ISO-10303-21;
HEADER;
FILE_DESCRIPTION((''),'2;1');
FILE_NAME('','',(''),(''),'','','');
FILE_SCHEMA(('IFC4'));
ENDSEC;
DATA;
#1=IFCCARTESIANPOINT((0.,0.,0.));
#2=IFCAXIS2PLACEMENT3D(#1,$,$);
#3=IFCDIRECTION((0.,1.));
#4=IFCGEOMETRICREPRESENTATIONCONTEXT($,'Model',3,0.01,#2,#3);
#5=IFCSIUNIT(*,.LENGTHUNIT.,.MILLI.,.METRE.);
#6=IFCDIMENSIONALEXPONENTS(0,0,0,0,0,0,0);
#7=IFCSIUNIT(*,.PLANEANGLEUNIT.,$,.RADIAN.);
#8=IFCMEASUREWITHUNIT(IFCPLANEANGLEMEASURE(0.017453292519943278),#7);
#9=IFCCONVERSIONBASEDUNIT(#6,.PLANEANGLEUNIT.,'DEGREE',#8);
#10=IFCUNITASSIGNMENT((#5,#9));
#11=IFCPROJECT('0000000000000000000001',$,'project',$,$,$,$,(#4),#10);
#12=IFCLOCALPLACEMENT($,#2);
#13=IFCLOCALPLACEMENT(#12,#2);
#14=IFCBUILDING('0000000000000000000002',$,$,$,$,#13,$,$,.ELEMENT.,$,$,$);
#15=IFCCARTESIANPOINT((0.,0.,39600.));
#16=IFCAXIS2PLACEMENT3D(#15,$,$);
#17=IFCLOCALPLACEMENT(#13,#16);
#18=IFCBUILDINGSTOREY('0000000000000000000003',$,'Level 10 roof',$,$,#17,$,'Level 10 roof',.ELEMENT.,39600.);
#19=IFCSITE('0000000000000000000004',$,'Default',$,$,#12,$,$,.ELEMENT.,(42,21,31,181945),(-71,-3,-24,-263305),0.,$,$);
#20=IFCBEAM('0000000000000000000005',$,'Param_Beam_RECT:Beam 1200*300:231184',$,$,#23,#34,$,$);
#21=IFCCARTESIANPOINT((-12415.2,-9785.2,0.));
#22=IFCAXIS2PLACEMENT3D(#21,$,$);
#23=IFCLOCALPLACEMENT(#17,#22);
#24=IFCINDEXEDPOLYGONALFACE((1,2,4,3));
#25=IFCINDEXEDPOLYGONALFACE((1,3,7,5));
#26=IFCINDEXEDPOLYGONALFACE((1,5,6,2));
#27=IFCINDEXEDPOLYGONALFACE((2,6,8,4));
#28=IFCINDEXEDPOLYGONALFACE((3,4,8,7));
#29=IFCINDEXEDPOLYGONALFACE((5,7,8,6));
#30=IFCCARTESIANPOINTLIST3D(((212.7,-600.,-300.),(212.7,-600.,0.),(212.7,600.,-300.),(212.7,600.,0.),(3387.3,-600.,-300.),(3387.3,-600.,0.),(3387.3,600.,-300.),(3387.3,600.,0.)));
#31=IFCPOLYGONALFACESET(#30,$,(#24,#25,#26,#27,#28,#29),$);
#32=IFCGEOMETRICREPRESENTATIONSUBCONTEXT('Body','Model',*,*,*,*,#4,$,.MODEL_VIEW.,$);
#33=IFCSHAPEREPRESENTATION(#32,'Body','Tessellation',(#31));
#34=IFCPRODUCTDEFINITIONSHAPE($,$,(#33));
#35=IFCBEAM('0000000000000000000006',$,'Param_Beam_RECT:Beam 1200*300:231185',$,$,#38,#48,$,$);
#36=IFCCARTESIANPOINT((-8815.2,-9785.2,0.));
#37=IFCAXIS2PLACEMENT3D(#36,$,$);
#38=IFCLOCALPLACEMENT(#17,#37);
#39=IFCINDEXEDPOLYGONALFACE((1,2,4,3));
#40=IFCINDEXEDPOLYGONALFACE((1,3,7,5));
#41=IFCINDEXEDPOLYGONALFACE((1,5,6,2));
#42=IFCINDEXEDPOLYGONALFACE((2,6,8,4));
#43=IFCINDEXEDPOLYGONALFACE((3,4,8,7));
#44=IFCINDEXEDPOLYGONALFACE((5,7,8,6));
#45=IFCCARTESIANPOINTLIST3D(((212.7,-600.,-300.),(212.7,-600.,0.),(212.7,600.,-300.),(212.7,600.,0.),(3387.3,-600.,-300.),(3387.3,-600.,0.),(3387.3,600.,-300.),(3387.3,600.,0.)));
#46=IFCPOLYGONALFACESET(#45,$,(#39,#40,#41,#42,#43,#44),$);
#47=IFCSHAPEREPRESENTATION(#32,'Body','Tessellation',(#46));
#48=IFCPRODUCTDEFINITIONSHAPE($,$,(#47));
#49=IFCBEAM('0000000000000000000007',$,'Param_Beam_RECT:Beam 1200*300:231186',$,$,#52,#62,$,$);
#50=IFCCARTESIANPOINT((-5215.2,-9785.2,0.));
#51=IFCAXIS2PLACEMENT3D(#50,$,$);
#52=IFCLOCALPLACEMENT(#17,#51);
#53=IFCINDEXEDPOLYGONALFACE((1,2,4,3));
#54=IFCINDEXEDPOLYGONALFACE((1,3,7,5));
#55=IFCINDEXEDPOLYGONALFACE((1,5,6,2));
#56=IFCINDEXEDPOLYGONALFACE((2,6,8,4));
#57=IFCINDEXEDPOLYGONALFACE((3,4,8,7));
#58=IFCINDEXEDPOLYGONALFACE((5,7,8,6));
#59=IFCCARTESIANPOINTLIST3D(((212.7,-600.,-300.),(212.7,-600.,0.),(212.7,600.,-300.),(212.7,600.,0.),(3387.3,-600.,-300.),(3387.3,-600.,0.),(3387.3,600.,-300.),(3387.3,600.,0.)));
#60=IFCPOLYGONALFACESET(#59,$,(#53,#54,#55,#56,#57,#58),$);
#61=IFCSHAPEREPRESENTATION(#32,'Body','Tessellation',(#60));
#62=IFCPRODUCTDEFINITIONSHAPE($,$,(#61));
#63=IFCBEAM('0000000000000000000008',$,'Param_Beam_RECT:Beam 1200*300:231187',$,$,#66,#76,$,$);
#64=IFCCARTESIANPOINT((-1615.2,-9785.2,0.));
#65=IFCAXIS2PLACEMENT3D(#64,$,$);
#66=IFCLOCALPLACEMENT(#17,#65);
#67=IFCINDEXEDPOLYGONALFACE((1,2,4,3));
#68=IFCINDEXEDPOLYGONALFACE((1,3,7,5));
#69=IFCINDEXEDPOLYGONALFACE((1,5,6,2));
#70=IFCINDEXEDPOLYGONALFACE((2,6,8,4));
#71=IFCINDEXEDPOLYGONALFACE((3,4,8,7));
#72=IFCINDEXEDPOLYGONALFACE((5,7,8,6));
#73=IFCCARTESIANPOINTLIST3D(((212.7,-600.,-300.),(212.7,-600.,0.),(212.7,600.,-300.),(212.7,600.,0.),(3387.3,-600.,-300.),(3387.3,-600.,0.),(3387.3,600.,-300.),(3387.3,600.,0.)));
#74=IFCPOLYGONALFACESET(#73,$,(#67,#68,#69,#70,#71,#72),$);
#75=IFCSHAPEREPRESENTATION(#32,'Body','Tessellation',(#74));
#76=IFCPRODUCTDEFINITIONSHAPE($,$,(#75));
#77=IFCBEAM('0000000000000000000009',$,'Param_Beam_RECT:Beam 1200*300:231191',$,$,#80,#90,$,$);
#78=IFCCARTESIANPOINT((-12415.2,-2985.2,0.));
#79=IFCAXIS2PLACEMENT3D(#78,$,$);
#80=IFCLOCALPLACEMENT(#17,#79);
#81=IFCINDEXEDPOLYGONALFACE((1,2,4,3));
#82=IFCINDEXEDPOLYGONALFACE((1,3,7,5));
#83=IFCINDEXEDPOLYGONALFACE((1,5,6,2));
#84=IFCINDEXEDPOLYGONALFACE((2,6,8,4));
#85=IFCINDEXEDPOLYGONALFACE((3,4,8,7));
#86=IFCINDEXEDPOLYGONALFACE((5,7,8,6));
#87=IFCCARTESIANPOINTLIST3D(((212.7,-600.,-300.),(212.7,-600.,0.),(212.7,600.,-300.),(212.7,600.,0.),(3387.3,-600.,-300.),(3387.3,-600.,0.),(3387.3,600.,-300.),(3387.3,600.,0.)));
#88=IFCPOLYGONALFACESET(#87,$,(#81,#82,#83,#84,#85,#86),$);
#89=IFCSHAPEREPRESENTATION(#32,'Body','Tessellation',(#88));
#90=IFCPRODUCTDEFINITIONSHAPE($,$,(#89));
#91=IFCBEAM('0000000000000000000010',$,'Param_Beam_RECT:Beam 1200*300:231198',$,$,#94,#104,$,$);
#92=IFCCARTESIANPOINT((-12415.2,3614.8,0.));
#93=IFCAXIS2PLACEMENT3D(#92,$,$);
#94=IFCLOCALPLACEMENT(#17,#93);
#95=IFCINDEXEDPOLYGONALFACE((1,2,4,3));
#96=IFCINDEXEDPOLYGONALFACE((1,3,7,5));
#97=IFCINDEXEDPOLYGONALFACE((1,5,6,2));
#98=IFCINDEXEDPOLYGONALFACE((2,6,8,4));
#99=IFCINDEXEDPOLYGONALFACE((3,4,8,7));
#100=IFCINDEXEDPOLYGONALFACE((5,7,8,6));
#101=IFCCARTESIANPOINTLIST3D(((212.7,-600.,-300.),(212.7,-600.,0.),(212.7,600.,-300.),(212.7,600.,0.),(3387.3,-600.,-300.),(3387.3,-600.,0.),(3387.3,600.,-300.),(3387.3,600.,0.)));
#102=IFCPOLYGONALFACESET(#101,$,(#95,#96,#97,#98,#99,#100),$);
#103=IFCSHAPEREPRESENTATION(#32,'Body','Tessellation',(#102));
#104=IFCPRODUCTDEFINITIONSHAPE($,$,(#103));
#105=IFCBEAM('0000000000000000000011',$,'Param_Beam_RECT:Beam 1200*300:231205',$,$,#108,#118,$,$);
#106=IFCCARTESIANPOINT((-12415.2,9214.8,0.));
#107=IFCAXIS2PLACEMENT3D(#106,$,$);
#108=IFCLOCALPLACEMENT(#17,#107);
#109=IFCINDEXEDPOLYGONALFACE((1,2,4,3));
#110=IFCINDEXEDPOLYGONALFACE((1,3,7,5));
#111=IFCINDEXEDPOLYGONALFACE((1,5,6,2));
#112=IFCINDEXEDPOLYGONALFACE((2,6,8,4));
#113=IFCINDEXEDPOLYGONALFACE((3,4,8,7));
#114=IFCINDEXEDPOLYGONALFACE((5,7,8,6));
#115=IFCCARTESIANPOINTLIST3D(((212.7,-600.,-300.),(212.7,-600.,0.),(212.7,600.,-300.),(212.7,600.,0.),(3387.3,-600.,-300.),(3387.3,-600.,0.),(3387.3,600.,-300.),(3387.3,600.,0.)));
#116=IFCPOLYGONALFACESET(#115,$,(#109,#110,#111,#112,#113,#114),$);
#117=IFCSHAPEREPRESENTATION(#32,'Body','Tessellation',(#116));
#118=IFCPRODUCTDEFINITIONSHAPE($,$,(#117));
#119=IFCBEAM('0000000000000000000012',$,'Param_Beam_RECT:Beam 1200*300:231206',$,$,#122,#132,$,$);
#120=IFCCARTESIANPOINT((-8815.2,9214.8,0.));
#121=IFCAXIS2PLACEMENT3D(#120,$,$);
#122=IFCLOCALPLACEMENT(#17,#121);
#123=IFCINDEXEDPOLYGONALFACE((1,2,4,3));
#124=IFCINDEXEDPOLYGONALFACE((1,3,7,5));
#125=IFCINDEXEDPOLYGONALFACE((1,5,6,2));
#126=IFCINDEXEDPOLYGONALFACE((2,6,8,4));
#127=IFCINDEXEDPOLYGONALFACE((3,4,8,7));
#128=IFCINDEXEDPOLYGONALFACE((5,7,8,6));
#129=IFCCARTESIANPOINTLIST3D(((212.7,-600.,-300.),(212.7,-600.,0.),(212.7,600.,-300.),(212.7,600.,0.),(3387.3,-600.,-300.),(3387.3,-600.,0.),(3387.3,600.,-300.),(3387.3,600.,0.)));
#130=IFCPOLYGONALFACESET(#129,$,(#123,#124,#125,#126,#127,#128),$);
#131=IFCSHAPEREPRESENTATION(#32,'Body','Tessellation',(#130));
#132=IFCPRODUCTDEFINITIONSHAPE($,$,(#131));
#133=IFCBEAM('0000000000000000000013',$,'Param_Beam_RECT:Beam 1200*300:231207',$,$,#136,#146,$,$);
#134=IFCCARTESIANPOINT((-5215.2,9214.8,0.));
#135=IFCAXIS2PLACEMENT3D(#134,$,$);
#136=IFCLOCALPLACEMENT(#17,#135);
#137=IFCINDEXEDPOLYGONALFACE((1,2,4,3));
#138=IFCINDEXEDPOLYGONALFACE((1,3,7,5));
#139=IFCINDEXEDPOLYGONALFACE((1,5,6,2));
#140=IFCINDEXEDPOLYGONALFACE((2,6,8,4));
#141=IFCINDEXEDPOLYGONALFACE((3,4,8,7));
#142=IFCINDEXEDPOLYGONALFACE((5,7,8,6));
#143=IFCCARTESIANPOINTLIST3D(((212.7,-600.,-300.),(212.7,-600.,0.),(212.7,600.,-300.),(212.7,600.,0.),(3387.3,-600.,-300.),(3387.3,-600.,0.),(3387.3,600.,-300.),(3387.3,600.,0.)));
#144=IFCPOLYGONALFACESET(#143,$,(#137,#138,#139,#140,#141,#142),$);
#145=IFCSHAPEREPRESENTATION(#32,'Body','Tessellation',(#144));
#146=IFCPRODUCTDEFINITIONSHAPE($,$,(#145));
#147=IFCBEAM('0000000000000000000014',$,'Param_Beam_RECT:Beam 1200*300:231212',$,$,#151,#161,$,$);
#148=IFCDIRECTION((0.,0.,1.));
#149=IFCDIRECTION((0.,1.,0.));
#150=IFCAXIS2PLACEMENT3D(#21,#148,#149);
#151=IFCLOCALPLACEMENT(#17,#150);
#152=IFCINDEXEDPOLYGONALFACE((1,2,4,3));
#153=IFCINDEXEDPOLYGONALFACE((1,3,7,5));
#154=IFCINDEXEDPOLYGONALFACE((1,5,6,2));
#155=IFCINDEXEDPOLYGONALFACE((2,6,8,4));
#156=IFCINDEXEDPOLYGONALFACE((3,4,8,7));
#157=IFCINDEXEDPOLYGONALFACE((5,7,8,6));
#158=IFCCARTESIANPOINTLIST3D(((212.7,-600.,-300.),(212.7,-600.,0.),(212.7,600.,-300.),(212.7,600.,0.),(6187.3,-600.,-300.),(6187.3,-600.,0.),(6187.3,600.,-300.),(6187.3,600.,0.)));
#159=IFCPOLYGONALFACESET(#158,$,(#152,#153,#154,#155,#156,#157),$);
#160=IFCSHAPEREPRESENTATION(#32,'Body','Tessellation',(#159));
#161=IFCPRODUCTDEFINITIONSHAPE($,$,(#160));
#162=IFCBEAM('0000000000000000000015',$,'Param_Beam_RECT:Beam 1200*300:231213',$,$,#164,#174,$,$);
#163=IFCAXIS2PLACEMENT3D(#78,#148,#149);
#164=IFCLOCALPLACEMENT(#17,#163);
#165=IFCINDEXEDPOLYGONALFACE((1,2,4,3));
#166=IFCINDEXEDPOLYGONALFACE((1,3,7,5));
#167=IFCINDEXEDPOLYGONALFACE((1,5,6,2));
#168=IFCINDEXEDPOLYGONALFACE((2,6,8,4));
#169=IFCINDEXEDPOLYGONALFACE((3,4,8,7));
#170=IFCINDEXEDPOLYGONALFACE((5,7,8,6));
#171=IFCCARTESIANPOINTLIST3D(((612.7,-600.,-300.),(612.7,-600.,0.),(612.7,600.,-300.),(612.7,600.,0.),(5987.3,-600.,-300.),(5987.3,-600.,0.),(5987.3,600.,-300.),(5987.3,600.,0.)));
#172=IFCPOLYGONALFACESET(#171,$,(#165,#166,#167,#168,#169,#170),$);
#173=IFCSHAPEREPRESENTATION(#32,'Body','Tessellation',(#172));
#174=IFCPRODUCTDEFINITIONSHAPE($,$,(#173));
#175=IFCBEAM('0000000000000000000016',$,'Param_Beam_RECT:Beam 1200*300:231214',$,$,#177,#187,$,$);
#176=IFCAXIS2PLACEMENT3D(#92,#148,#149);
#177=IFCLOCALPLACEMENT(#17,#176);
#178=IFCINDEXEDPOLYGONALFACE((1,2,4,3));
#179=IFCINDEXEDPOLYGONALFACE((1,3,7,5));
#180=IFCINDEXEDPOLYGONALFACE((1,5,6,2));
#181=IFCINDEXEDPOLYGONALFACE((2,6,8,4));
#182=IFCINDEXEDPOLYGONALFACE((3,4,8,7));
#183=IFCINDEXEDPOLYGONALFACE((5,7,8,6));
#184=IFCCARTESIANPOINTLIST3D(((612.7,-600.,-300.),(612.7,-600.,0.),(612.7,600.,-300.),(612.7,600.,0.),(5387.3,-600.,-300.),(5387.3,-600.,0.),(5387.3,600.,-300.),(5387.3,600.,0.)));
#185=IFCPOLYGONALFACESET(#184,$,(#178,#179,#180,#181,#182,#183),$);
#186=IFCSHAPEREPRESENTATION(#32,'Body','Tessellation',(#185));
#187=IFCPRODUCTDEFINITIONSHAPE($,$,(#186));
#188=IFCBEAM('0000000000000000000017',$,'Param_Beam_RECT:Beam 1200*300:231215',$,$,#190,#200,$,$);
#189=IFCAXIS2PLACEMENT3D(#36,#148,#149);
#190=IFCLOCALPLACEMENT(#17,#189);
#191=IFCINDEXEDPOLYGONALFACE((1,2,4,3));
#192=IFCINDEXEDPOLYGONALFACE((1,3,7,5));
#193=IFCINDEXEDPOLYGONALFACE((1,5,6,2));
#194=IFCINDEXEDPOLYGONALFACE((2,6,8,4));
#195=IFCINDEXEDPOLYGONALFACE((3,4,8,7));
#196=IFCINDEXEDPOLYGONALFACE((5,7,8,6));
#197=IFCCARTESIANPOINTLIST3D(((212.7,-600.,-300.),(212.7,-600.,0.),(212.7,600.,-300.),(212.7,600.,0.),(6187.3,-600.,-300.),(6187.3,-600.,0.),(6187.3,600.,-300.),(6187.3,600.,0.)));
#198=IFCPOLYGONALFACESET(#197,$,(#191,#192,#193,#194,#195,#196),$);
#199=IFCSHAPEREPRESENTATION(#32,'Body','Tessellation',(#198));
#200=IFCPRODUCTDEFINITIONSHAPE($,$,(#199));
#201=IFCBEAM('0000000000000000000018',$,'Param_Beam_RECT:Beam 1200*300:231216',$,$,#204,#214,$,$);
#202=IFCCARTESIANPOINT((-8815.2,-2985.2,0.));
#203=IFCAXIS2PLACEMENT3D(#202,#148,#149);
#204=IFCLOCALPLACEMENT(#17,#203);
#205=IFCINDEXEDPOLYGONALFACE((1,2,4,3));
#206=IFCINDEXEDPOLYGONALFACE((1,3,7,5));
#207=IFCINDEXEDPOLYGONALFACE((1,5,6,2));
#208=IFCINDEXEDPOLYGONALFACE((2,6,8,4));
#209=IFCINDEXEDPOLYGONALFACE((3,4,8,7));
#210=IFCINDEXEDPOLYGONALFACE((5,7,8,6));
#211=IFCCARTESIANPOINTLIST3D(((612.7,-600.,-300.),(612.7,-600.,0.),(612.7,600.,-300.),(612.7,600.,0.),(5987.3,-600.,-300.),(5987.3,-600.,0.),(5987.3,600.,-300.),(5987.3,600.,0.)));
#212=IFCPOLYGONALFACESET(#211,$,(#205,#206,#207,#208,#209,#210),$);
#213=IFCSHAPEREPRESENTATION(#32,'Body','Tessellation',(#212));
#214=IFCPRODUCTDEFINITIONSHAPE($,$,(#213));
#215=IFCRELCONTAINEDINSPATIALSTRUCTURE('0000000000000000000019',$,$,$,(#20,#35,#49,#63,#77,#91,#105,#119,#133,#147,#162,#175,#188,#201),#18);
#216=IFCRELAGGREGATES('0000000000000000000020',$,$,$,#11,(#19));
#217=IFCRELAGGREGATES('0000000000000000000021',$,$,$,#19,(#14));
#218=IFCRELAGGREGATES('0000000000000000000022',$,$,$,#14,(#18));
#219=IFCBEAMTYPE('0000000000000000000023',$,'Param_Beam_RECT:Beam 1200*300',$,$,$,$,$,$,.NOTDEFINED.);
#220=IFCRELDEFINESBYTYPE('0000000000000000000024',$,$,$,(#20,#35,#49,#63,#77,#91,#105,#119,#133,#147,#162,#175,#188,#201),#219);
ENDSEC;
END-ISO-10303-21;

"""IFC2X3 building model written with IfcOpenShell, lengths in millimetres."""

from ifc_helpers import new_model, entity, si_unit, converted_unit, direction, frame, frame_2d, origin, origin_2d_with_axis, place, context, subcontext, project, spatial, rectangle, extrude, type_object, element, save


model = new_model("IFC2X3")

# Units and contexts
model_context = context("Model", 3, precision=0.01, world=origin(), true_north=direction((0.0, 1.0)))
body_context = subcontext(model_context, "Body", "Model", "MODEL_VIEW")
ifc_project = project(units=[si_unit("LENGTHUNIT", "METRE", prefix="MILLI"), converted_unit("PLANEANGLEUNIT", "DEGREE", entity("IfcPlaneAngleMeasure", 0.017453292519943278), si_unit("PLANEANGLEUNIT", "RADIAN"), dimensions=[0, 0, 0, 0, 0, 0, 0])], contexts=[model_context])

# Site, building, storey
site_placement = place(None, origin())
site = spatial("IfcSite", under=ifc_project, at=site_placement, Name="Default", CompositionType="ELEMENT", RefLatitude=(42, 21, 31, 181945), RefLongitude=(-71, -3, -24, -263305), RefElevation=0.0)
building_placement = place(site_placement, origin())
building = spatial("IfcBuilding", under=site, at=building_placement, CompositionType="ELEMENT")
storey_placement = place(building_placement, frame((0.0, 0.0, 39600.0)))
storey = spatial("IfcBuildingStorey", under=building, at=storey_placement, Name="Level 10 roof", LongName="Level 10 roof", CompositionType="ELEMENT", Elevation=39600.0)

# Beams
beam_type_1 = type_object("IfcBeamType", Name="Param_Beam_RECT:Beam 1200*300", PredefinedType="NOTDEFINED")
beam_1_placement = place(storey_placement, frame((-12415.2, -9785.2, 0.0)))
element("IfcBeam", 1, at=beam_1_placement, inside=storey, type_object=beam_type_1, Name="Param_Beam_RECT:Beam 1200*300:231184", context=body_context, shape_type="SweptSolid", body=[
    extrude(rectangle(XDim=300.0, YDim=1200.0, at=frame_2d((0.0, 0.0), x_axis=(1.0, 0.0))), frame((212.7, 0.0, -150.0), z_axis=(1.0, 0.0, 0.0), x_axis=(0.0, 0.0, -1.0)), (0.0, 0.0, 1.0), 3174.6),
])
beam_2_placement = place(storey_placement, frame((-8815.2, -9785.2, 0.0)))
element("IfcBeam", 2, at=beam_2_placement, inside=storey, type_object=beam_type_1, Name="Param_Beam_RECT:Beam 1200*300:231185", context=body_context, shape_type="SweptSolid", body=[
    extrude(rectangle(XDim=300.0, YDim=1200.0, at=frame_2d((0.0, 0.0), x_axis=(1.0, 0.0))), frame((212.7, 0.0, -150.0), z_axis=(1.0, 0.0, 0.0), x_axis=(0.0, 0.0, -1.0)), (0.0, 0.0, 1.0), 3174.6),
])
beam_3_placement = place(storey_placement, frame((-5215.2, -9785.2, 0.0)))
element("IfcBeam", 3, at=beam_3_placement, inside=storey, type_object=beam_type_1, Name="Param_Beam_RECT:Beam 1200*300:231186", context=body_context, shape_type="SweptSolid", body=[
    extrude(rectangle(XDim=300.0, YDim=1200.0, at=frame_2d((0.0, 0.0), x_axis=(1.0, 0.0))), frame((212.7, 0.0, -150.0), z_axis=(1.0, 0.0, 0.0), x_axis=(0.0, 0.0, -1.0)), (0.0, 0.0, 1.0), 3174.6),
])
beam_4_placement = place(storey_placement, frame((-1615.2, -9785.2, 0.0)))
element("IfcBeam", 4, at=beam_4_placement, inside=storey, type_object=beam_type_1, Name="Param_Beam_RECT:Beam 1200*300:231187", context=body_context, shape_type="SweptSolid", body=[
    extrude(rectangle(XDim=300.0, YDim=1200.0, at=origin_2d_with_axis()), frame((212.7, 0.0, -150.0), z_axis=(1.0, 0.0, 0.0), x_axis=(0.0, 0.0, -1.0)), (0.0, 0.0, 1.0), 3174.6),
])
beam_5_placement = place(storey_placement, frame((-12415.2, -2985.2, 0.0)))
element("IfcBeam", 5, at=beam_5_placement, inside=storey, type_object=beam_type_1, Name="Param_Beam_RECT:Beam 1200*300:231191", context=body_context, shape_type="SweptSolid", body=[
    extrude(rectangle(XDim=300.0, YDim=1200.0, at=frame_2d((0.0, 0.0), x_axis=(1.0, 0.0))), frame((212.7, 0.0, -150.0), z_axis=(1.0, 0.0, 0.0), x_axis=(0.0, 0.0, -1.0)), (0.0, 0.0, 1.0), 3174.6),
])
beam_6_placement = place(storey_placement, frame((-12415.2, 3614.8, 0.0)))
element("IfcBeam", 6, at=beam_6_placement, inside=storey, type_object=beam_type_1, Name="Param_Beam_RECT:Beam 1200*300:231198", context=body_context, shape_type="SweptSolid", body=[
    extrude(rectangle(XDim=300.0, YDim=1200.0, at=origin_2d_with_axis()), frame((212.7, 0.0, -150.0), z_axis=(1.0, 0.0, 0.0), x_axis=(0.0, 0.0, -1.0)), (0.0, 0.0, 1.0), 3174.6),
])
beam_7_placement = place(storey_placement, frame((-12415.2, 9214.8, 0.0)))
element("IfcBeam", 7, at=beam_7_placement, inside=storey, type_object=beam_type_1, Name="Param_Beam_RECT:Beam 1200*300:231205", context=body_context, shape_type="SweptSolid", body=[
    extrude(rectangle(XDim=300.0, YDim=1200.0, at=frame_2d((0.0, 0.0), x_axis=(1.0, 0.0))), frame((212.7, 0.0, -150.0), z_axis=(1.0, 0.0, 0.0), x_axis=(0.0, 0.0, -1.0)), (0.0, 0.0, 1.0), 3174.6),
])
for number, where, name in (
    (8, (-8815.2, 9214.8, 0.0), "Param_Beam_RECT:Beam 1200*300:231206"),
    (9, (-5215.2, 9214.8, 0.0), "Param_Beam_RECT:Beam 1200*300:231207"),
):
    element("IfcBeam", number, at=place(storey_placement, frame(where)), inside=storey, type_object=beam_type_1, Name=name, context=body_context, shape_type="SweptSolid", body=[
        extrude(rectangle(XDim=300.0, YDim=1200.0, at=frame_2d((0.0, 0.0), x_axis=(1.0, 0.0))), frame((212.7, 0.0, -150.0), z_axis=(1.0, 0.0, 0.0), x_axis=(0.0, 0.0, -1.0)), (0.0, 0.0, 1.0), 3174.6),
    ])
beam_8_placement = place(storey_placement, frame((-12415.2, -9785.2, 0.0), z_axis=(0.0, 0.0, 1.0), x_axis=(0.0, 1.0, 0.0)))
element("IfcBeam", 10, at=beam_8_placement, inside=storey, type_object=beam_type_1, Name="Param_Beam_RECT:Beam 1200*300:231212", context=body_context, shape_type="SweptSolid", body=[
    extrude(rectangle(XDim=300.0, YDim=1200.0, at=origin_2d_with_axis()), frame((212.7, 0.0, -150.0), z_axis=(1.0, 0.0, 0.0), x_axis=(0.0, 0.0, -1.0)), (0.0, 0.0, 1.0), 5974.6),
])
beam_9_placement = place(storey_placement, frame((-12415.2, -2985.2, 0.0), z_axis=(0.0, 0.0, 1.0), x_axis=(0.0, 1.0, 0.0)))
element("IfcBeam", 11, at=beam_9_placement, inside=storey, type_object=beam_type_1, Name="Param_Beam_RECT:Beam 1200*300:231213", context=body_context, shape_type="SweptSolid", body=[
    extrude(rectangle(XDim=300.0, YDim=1200.0, at=frame_2d((0.0, 0.0), x_axis=(1.0, 0.0))), frame((612.7, 0.0, -150.0), z_axis=(1.0, 0.0, 0.0), x_axis=(0.0, 0.0, -1.0)), (0.0, 0.0, 1.0), 5374.6),
])
beam_10_placement = place(storey_placement, frame((-12415.2, 3614.8, 0.0), z_axis=(0.0, 0.0, 1.0), x_axis=(0.0, 1.0, 0.0)))
element("IfcBeam", 12, at=beam_10_placement, inside=storey, type_object=beam_type_1, Name="Param_Beam_RECT:Beam 1200*300:231214", context=body_context, shape_type="SweptSolid", body=[
    extrude(rectangle(XDim=300.0, YDim=1200.0, at=origin_2d_with_axis()), frame((612.7, 0.0, -150.0), z_axis=(1.0, 0.0, 0.0), x_axis=(0.0, 0.0, -1.0)), (0.0, 0.0, 1.0), 4774.6),
])
beam_11_placement = place(storey_placement, frame((-8815.2, -9785.2, 0.0), z_axis=(0.0, 0.0, 1.0), x_axis=(0.0, 1.0, 0.0)))
element("IfcBeam", 13, at=beam_11_placement, inside=storey, type_object=beam_type_1, Name="Param_Beam_RECT:Beam 1200*300:231215", context=body_context, shape_type="SweptSolid", body=[
    extrude(rectangle(XDim=300.0, YDim=1200.0, at=frame_2d((0.0, 0.0), x_axis=(1.0, 0.0))), frame((212.7, 0.0, -150.0), z_axis=(1.0, 0.0, 0.0), x_axis=(0.0, 0.0, -1.0)), (0.0, 0.0, 1.0), 5974.6),
])
beam_12_placement = place(storey_placement, frame((-8815.2, -2985.2, 0.0), z_axis=(0.0, 0.0, 1.0), x_axis=(0.0, 1.0, 0.0)))
element("IfcBeam", 14, at=beam_12_placement, inside=storey, type_object=beam_type_1, Name="Param_Beam_RECT:Beam 1200*300:231216", context=body_context, shape_type="SweptSolid", body=[
    extrude(rectangle(XDim=300.0, YDim=1200.0, at=frame_2d((0.0, 0.0), x_axis=(1.0, 0.0))), frame((612.7, 0.0, -150.0), z_axis=(1.0, 0.0, 0.0), x_axis=(0.0, 0.0, -1.0)), (0.0, 0.0, 1.0), 5374.6),
])

save(model, "model.ifc")
